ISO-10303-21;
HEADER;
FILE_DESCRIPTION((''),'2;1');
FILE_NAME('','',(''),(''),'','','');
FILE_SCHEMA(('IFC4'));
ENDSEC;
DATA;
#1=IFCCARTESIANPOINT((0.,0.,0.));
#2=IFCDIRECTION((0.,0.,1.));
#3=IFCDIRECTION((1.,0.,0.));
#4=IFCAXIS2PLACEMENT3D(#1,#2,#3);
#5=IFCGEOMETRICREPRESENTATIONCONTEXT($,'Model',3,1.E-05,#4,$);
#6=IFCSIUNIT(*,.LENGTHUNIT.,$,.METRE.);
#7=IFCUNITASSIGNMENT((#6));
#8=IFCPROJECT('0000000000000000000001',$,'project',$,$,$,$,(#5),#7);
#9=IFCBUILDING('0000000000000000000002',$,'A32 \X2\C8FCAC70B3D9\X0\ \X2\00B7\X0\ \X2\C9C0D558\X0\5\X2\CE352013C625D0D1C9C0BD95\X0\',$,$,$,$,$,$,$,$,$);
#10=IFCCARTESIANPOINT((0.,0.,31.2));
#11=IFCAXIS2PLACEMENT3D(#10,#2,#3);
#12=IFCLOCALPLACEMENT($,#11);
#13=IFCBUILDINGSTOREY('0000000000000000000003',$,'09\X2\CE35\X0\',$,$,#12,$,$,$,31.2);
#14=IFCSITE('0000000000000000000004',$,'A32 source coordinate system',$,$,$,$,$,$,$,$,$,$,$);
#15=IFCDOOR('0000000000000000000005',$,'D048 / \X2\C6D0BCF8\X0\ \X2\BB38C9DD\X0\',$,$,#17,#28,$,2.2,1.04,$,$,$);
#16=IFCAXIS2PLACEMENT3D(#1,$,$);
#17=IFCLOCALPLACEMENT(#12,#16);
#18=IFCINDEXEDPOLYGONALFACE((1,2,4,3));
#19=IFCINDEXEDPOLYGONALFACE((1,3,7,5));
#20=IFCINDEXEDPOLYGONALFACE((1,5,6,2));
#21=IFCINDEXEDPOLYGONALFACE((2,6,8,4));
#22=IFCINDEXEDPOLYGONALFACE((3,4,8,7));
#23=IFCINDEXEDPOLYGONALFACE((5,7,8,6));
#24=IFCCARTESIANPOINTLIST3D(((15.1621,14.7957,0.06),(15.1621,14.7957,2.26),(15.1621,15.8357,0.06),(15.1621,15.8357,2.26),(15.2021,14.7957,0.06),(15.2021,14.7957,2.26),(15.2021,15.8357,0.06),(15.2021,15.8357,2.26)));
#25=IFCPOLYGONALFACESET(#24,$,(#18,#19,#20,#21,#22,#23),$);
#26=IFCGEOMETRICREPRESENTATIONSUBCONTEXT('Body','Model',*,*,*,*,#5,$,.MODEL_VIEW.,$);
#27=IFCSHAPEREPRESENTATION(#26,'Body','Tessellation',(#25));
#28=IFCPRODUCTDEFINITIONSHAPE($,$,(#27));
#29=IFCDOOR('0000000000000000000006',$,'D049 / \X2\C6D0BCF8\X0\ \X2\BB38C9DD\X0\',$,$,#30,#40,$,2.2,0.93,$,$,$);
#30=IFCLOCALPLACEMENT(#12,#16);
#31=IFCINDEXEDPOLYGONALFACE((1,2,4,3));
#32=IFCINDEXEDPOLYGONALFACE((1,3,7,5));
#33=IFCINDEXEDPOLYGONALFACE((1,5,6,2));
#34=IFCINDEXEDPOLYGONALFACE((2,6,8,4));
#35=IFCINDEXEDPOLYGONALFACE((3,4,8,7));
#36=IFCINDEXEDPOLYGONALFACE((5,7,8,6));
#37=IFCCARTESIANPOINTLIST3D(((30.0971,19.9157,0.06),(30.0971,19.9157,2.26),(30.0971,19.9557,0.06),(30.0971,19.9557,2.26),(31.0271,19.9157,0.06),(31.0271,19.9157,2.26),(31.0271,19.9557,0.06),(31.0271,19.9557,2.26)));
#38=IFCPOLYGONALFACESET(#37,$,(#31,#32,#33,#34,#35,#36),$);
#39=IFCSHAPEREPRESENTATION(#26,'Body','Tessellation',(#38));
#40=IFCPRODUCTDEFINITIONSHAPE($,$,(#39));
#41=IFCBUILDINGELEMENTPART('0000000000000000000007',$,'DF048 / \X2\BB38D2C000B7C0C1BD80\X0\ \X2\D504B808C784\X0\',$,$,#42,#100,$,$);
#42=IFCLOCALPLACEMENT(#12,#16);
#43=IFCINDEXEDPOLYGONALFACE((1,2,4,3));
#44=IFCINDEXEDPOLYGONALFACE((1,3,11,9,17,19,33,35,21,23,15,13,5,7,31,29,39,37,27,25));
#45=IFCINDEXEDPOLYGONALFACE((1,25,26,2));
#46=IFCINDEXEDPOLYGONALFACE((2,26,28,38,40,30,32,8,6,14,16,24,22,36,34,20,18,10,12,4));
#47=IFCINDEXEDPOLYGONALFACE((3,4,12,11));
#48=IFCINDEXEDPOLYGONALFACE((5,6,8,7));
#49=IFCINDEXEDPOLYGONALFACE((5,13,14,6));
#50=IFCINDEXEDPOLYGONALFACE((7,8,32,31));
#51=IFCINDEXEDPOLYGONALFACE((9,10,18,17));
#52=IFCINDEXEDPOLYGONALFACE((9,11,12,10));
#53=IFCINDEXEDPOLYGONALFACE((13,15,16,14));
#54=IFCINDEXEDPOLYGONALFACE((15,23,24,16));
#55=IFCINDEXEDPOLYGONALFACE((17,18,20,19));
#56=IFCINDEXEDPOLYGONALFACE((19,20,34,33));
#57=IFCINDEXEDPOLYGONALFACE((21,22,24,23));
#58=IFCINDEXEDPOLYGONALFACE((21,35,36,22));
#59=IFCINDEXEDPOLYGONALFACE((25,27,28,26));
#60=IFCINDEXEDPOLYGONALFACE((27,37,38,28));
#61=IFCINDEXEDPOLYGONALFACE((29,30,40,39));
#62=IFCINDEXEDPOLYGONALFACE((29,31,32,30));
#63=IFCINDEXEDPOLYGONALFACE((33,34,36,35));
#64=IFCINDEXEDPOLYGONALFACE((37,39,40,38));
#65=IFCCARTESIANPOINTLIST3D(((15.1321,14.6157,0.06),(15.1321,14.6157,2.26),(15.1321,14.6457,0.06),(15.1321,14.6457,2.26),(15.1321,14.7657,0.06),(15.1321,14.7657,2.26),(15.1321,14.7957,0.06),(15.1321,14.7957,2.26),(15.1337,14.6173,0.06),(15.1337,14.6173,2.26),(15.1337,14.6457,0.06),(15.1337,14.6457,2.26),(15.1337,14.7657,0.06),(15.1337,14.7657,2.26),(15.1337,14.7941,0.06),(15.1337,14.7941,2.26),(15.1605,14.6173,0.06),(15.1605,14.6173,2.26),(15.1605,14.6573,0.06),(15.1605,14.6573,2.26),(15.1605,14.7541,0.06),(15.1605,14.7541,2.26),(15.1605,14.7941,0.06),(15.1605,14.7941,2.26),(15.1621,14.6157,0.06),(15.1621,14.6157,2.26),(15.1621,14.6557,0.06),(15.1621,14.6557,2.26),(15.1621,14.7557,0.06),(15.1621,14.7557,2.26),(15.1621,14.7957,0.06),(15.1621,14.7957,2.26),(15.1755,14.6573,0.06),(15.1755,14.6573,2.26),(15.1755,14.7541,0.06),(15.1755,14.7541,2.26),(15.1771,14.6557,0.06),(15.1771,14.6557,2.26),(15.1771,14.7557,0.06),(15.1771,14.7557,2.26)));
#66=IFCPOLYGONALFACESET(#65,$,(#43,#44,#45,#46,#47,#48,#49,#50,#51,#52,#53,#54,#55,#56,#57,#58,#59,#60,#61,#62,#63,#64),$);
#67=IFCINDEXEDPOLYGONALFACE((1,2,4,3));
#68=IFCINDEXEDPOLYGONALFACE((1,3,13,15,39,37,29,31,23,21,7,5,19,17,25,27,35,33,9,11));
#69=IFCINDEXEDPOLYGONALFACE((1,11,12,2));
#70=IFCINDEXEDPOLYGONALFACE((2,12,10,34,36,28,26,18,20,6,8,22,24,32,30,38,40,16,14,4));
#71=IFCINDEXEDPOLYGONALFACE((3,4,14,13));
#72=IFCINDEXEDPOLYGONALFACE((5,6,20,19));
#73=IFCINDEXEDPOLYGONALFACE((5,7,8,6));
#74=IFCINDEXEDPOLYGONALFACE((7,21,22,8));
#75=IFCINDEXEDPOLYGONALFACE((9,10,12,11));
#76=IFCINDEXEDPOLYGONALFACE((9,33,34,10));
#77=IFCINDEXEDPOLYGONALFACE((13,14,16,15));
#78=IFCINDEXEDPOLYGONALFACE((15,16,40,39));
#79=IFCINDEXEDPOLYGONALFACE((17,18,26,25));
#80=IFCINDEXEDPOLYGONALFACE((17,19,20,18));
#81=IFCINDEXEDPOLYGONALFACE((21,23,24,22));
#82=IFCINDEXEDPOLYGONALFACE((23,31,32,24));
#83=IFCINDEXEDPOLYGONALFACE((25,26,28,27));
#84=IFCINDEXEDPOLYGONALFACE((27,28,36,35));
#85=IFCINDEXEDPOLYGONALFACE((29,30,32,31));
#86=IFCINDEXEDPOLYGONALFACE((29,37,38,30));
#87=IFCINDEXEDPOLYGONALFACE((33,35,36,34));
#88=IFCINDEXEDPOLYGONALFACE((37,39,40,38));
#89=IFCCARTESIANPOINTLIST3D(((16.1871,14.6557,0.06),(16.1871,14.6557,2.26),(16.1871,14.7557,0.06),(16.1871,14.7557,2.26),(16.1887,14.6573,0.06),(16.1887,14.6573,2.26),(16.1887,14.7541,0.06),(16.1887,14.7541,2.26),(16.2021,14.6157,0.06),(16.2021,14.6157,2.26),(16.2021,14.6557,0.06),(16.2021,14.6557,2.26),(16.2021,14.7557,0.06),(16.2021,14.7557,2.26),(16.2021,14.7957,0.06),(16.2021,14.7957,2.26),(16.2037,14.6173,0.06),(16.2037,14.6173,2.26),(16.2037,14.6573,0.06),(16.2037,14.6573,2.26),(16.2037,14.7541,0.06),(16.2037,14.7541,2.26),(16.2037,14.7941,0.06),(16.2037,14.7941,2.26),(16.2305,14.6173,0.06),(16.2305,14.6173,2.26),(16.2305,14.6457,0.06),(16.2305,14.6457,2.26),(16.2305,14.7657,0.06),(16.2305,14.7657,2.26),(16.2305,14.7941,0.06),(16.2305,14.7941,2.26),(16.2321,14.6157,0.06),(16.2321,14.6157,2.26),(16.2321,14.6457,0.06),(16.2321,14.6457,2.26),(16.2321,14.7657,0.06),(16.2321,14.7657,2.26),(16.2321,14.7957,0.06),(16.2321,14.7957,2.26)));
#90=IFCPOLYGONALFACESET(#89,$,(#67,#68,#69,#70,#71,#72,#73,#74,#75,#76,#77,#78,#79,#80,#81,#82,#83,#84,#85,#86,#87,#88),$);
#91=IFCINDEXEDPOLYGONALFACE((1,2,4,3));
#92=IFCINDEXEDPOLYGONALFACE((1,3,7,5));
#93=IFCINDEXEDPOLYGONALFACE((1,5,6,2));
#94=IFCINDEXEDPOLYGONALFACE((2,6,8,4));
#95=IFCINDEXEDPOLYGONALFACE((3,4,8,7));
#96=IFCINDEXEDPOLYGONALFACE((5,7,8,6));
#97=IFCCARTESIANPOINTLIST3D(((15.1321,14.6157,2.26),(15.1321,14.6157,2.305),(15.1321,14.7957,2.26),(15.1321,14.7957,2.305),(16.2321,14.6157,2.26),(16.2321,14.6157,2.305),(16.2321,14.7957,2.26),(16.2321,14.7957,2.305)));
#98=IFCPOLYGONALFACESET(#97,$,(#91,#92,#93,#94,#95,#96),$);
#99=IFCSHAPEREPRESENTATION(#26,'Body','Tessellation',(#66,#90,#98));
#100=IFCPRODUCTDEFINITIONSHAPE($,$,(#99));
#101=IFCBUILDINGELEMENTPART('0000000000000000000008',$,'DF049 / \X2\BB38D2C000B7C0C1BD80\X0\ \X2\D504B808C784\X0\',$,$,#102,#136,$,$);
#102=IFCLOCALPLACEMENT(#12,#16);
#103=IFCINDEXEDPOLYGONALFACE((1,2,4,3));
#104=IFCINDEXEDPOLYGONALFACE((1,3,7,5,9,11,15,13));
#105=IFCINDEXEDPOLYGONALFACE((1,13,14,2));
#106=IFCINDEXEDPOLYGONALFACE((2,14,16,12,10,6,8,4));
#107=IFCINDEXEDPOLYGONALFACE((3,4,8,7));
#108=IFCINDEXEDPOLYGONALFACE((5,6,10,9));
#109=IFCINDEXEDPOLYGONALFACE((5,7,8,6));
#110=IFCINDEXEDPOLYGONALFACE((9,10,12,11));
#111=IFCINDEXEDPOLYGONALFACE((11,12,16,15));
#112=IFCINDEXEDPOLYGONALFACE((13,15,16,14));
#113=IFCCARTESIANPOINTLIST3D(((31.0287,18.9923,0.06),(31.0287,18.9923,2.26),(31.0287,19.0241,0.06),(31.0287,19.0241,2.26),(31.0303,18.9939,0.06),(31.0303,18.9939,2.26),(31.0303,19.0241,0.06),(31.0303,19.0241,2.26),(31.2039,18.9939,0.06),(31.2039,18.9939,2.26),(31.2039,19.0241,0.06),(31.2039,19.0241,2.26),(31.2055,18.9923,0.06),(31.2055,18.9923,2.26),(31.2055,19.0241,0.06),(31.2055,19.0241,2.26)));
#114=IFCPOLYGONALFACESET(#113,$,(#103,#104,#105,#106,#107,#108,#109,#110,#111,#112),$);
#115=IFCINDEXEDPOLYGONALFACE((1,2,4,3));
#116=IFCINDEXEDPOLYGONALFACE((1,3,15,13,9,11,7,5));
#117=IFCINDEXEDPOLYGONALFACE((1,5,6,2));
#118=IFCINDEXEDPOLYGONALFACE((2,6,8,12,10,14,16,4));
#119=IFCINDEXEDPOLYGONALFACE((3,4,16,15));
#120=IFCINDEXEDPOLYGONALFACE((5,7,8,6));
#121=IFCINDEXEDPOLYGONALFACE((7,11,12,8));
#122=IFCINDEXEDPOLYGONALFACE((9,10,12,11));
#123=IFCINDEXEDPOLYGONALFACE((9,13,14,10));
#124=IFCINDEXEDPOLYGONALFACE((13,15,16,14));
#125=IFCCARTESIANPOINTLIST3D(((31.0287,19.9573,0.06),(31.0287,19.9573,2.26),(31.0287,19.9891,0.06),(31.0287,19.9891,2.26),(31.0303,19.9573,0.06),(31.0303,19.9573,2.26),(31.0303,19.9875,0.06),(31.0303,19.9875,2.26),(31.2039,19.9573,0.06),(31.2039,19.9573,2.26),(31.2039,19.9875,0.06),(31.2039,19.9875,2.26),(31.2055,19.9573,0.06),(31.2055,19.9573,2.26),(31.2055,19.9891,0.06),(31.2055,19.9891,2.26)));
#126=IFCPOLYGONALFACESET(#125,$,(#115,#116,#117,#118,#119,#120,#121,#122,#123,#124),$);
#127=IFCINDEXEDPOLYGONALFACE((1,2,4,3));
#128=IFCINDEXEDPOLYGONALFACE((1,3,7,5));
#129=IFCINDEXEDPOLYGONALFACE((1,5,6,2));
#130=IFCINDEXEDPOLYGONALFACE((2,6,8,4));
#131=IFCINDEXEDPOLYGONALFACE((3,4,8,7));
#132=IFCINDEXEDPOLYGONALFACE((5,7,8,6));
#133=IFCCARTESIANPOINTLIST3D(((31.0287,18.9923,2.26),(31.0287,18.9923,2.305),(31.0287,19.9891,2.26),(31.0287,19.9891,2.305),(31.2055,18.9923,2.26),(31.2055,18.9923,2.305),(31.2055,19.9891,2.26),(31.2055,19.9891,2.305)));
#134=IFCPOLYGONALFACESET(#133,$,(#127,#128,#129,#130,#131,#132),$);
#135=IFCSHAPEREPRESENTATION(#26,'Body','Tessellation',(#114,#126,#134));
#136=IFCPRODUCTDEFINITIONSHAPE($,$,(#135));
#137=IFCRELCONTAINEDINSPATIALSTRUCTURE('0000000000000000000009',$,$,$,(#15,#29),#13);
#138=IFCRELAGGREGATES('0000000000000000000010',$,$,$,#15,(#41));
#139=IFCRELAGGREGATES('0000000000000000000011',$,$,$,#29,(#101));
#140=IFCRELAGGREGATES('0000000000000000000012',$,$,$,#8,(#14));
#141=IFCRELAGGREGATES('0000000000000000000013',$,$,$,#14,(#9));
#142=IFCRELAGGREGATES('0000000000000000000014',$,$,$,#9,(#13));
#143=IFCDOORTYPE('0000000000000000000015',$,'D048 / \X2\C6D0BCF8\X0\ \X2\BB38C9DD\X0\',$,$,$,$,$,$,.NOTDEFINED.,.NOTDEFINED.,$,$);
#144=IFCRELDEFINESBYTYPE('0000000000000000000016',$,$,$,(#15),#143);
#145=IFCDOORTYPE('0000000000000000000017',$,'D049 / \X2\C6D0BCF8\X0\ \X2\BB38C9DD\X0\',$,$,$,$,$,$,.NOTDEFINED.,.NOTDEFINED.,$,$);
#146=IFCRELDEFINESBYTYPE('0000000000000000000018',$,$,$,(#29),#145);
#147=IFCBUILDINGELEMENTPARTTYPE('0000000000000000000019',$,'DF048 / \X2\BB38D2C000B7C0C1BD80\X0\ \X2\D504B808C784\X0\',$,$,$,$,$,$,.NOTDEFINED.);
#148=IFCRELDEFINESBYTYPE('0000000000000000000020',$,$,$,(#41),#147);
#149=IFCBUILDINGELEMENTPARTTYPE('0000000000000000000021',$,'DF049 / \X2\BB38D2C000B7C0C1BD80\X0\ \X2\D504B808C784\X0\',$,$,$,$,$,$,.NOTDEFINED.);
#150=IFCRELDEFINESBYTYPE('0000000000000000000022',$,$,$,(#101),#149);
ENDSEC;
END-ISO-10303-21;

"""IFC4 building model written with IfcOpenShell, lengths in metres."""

from ifc_helpers import new_model, si_unit, frame, origin, origin_with_axes, place, context, subcontext, project, spatial, polyline, outline, extrude, source, transform, mapped, type_object, type_shapes, element, aggregate, save


model = new_model("IFC4")

# Units and contexts
model_context = context("Model", 3, precision=1e-05, world=origin_with_axes())
body_context = subcontext(model_context, "Body", "Model", "MODEL_VIEW")
ifc_project = project(units=[si_unit("LENGTHUNIT", "METRE")], contexts=[model_context])

# Site, building, storey
storey_placement = place(None, frame((0.0, 0.0, 31.2), z_axis=(0.0, 0.0, 1.0), x_axis=(1.0, 0.0, 0.0)))
site = spatial("IfcSite", under=ifc_project, Name="A32 source coordinate system")
building = spatial("IfcBuilding", under=site, Name="A32 주거동 · 지하5층–옥탑지붕")
storey = spatial("IfcBuildingStorey", under=building, at=storey_placement, Name="09층", Elevation=31.2)

# Doors
door_type_1 = type_object("IfcDoorType", Name="D048 / 원본 문짝", OperationType="NOTDEFINED", PredefinedType="NOTDEFINED")
shared_shape_1 = source(origin(), body_context, "Body", "SweptSolid", [
    extrude(outline(polyline([(15.2021, 15.8357), (15.2021, 14.7957), (15.1621, 14.7957), (15.1621, 15.8357), (15.2021, 15.8357)])), frame((0.0, 0.0, 0.06)), (0.0, 0.0, 1.0), 2.2),
])
type_shapes(door_type_1, [shared_shape_1])
door_1_placement = place(storey_placement, origin_with_axes())
door_1 = element("IfcDoor", 1, at=door_1_placement, inside=storey, type_object=door_type_1, Name="D048 / 원본 문짝", OverallHeight=2.2, OverallWidth=1.04, context=body_context, shape_type="MappedRepresentation", body=[
    mapped(shared_shape_1, transform((0.0, 0.0, 0.0), scale=1.0)),
])
door_type_2 = type_object("IfcDoorType", Name="D049 / 원본 문짝", OperationType="NOTDEFINED", PredefinedType="NOTDEFINED")
shared_shape_2 = source(origin(), body_context, "Body", "SweptSolid", [
    extrude(outline(polyline([(31.0271, 19.9557), (31.0271, 19.9157), (30.0971, 19.9157), (30.0971, 19.9557), (31.0271, 19.9557)])), frame((0.0, 0.0, 0.06)), (0.0, 0.0, 1.0), 2.2),
])
type_shapes(door_type_2, [shared_shape_2])
door_2_placement = place(storey_placement, origin_with_axes())
door_2 = element("IfcDoor", 2, at=door_2_placement, inside=storey, type_object=door_type_2, Name="D049 / 원본 문짝", OverallHeight=2.2, OverallWidth=0.93, context=body_context, shape_type="MappedRepresentation", body=[
    mapped(shared_shape_2, transform((0.0, 0.0, 0.0), scale=1.0)),
])

# Building element parts
building_element_part_type_1 = type_object("IfcBuildingElementPartType", Name="DF048 / 문틀·상부 프레임", PredefinedType="NOTDEFINED")
shared_shape_3 = source(origin(), body_context, "Body", "SweptSolid", [
    extrude(outline(polyline([(15.1321, 14.7657), (15.1321, 14.7957), (15.1621, 14.7957), (15.1621, 14.7557), (15.1771, 14.7557), (15.1771, 14.6557), (15.1621, 14.6557), (15.1621, 14.6157), (15.1321, 14.6157), (15.1321, 14.6457), (15.1337, 14.6457), (15.1337, 14.6173), (15.1605, 14.6173), (15.1605, 14.6573), (15.1755, 14.6573), (15.1755, 14.7541), (15.1605, 14.7541), (15.1605, 14.7941), (15.1337, 14.7941), (15.1337, 14.7657), (15.1321, 14.7657)])), frame((0.0, 0.0, 0.06)), (0.0, 0.0, 1.0), 2.2),
    extrude(outline(polyline([(16.2305, 14.7941), (16.2037, 14.7941), (16.2037, 14.7541), (16.1887, 14.7541), (16.1887, 14.6573), (16.2037, 14.6573), (16.2037, 14.6173), (16.2305, 14.6173), (16.2305, 14.6457), (16.2321, 14.6457), (16.2321, 14.6157), (16.2021, 14.6157), (16.2021, 14.6557), (16.1871, 14.6557), (16.1871, 14.7557), (16.2021, 14.7557), (16.2021, 14.7957), (16.2321, 14.7957), (16.2321, 14.7657), (16.2305, 14.7657), (16.2305, 14.7941)])), frame((0.0, 0.0, 0.06)), (0.0, 0.0, 1.0), 2.2),
    extrude(outline(polyline([(15.1321, 14.6157), (15.1321, 14.7957), (16.2321, 14.7957), (16.2321, 14.6157), (15.1321, 14.6157)])), frame((0.0, 0.0, 2.26)), (0.0, 0.0, 1.0), 0.045),
])
type_shapes(building_element_part_type_1, [shared_shape_3])
building_element_part_1_placement = place(door_1_placement, origin_with_axes())
building_element_part_1 = element("IfcBuildingElementPart", 3, at=building_element_part_1_placement, type_object=building_element_part_type_1, Name="DF048 / 문틀·상부 프레임", context=body_context, shape_type="MappedRepresentation", body=[
    mapped(shared_shape_3, transform((0.0, 0.0, 0.0), scale=1.0)),
])
aggregate(door_1, [building_element_part_1])
building_element_part_type_2 = type_object("IfcBuildingElementPartType", Name="DF049 / 문틀·상부 프레임", PredefinedType="NOTDEFINED")
shared_shape_4 = source(origin(), body_context, "Body", "SweptSolid", [
    extrude(outline(polyline([(31.0303, 19.0241), (31.0303, 18.9939), (31.2039, 18.9939), (31.2039, 19.0241), (31.2055, 19.0241), (31.2055, 18.9923), (31.0287, 18.9923), (31.0287, 19.0241), (31.0303, 19.0241)])), frame((0.0, 0.0, 0.06)), (0.0, 0.0, 1.0), 2.2),
    extrude(outline(polyline([(31.0287, 19.9891), (31.2055, 19.9891), (31.2055, 19.9573), (31.2039, 19.9573), (31.2039, 19.9875), (31.0303, 19.9875), (31.0303, 19.9573), (31.0287, 19.9573), (31.0287, 19.9891)])), frame((0.0, 0.0, 0.06)), (0.0, 0.0, 1.0), 2.2),
    extrude(outline(polyline([(31.0287, 18.9923), (31.0287, 19.9891), (31.2055, 19.9891), (31.2055, 18.9923), (31.0287, 18.9923)])), frame((0.0, 0.0, 2.26)), (0.0, 0.0, 1.0), 0.045),
])
type_shapes(building_element_part_type_2, [shared_shape_4])
building_element_part_2_placement = place(door_2_placement, origin_with_axes())
building_element_part_2 = element("IfcBuildingElementPart", 4, at=building_element_part_2_placement, type_object=building_element_part_type_2, Name="DF049 / 문틀·상부 프레임", context=body_context, shape_type="MappedRepresentation", body=[
    mapped(shared_shape_4, transform((0.0, 0.0, 0.0), scale=1.0)),
])
aggregate(door_2, [building_element_part_2])

save(model, "model.ifc")
